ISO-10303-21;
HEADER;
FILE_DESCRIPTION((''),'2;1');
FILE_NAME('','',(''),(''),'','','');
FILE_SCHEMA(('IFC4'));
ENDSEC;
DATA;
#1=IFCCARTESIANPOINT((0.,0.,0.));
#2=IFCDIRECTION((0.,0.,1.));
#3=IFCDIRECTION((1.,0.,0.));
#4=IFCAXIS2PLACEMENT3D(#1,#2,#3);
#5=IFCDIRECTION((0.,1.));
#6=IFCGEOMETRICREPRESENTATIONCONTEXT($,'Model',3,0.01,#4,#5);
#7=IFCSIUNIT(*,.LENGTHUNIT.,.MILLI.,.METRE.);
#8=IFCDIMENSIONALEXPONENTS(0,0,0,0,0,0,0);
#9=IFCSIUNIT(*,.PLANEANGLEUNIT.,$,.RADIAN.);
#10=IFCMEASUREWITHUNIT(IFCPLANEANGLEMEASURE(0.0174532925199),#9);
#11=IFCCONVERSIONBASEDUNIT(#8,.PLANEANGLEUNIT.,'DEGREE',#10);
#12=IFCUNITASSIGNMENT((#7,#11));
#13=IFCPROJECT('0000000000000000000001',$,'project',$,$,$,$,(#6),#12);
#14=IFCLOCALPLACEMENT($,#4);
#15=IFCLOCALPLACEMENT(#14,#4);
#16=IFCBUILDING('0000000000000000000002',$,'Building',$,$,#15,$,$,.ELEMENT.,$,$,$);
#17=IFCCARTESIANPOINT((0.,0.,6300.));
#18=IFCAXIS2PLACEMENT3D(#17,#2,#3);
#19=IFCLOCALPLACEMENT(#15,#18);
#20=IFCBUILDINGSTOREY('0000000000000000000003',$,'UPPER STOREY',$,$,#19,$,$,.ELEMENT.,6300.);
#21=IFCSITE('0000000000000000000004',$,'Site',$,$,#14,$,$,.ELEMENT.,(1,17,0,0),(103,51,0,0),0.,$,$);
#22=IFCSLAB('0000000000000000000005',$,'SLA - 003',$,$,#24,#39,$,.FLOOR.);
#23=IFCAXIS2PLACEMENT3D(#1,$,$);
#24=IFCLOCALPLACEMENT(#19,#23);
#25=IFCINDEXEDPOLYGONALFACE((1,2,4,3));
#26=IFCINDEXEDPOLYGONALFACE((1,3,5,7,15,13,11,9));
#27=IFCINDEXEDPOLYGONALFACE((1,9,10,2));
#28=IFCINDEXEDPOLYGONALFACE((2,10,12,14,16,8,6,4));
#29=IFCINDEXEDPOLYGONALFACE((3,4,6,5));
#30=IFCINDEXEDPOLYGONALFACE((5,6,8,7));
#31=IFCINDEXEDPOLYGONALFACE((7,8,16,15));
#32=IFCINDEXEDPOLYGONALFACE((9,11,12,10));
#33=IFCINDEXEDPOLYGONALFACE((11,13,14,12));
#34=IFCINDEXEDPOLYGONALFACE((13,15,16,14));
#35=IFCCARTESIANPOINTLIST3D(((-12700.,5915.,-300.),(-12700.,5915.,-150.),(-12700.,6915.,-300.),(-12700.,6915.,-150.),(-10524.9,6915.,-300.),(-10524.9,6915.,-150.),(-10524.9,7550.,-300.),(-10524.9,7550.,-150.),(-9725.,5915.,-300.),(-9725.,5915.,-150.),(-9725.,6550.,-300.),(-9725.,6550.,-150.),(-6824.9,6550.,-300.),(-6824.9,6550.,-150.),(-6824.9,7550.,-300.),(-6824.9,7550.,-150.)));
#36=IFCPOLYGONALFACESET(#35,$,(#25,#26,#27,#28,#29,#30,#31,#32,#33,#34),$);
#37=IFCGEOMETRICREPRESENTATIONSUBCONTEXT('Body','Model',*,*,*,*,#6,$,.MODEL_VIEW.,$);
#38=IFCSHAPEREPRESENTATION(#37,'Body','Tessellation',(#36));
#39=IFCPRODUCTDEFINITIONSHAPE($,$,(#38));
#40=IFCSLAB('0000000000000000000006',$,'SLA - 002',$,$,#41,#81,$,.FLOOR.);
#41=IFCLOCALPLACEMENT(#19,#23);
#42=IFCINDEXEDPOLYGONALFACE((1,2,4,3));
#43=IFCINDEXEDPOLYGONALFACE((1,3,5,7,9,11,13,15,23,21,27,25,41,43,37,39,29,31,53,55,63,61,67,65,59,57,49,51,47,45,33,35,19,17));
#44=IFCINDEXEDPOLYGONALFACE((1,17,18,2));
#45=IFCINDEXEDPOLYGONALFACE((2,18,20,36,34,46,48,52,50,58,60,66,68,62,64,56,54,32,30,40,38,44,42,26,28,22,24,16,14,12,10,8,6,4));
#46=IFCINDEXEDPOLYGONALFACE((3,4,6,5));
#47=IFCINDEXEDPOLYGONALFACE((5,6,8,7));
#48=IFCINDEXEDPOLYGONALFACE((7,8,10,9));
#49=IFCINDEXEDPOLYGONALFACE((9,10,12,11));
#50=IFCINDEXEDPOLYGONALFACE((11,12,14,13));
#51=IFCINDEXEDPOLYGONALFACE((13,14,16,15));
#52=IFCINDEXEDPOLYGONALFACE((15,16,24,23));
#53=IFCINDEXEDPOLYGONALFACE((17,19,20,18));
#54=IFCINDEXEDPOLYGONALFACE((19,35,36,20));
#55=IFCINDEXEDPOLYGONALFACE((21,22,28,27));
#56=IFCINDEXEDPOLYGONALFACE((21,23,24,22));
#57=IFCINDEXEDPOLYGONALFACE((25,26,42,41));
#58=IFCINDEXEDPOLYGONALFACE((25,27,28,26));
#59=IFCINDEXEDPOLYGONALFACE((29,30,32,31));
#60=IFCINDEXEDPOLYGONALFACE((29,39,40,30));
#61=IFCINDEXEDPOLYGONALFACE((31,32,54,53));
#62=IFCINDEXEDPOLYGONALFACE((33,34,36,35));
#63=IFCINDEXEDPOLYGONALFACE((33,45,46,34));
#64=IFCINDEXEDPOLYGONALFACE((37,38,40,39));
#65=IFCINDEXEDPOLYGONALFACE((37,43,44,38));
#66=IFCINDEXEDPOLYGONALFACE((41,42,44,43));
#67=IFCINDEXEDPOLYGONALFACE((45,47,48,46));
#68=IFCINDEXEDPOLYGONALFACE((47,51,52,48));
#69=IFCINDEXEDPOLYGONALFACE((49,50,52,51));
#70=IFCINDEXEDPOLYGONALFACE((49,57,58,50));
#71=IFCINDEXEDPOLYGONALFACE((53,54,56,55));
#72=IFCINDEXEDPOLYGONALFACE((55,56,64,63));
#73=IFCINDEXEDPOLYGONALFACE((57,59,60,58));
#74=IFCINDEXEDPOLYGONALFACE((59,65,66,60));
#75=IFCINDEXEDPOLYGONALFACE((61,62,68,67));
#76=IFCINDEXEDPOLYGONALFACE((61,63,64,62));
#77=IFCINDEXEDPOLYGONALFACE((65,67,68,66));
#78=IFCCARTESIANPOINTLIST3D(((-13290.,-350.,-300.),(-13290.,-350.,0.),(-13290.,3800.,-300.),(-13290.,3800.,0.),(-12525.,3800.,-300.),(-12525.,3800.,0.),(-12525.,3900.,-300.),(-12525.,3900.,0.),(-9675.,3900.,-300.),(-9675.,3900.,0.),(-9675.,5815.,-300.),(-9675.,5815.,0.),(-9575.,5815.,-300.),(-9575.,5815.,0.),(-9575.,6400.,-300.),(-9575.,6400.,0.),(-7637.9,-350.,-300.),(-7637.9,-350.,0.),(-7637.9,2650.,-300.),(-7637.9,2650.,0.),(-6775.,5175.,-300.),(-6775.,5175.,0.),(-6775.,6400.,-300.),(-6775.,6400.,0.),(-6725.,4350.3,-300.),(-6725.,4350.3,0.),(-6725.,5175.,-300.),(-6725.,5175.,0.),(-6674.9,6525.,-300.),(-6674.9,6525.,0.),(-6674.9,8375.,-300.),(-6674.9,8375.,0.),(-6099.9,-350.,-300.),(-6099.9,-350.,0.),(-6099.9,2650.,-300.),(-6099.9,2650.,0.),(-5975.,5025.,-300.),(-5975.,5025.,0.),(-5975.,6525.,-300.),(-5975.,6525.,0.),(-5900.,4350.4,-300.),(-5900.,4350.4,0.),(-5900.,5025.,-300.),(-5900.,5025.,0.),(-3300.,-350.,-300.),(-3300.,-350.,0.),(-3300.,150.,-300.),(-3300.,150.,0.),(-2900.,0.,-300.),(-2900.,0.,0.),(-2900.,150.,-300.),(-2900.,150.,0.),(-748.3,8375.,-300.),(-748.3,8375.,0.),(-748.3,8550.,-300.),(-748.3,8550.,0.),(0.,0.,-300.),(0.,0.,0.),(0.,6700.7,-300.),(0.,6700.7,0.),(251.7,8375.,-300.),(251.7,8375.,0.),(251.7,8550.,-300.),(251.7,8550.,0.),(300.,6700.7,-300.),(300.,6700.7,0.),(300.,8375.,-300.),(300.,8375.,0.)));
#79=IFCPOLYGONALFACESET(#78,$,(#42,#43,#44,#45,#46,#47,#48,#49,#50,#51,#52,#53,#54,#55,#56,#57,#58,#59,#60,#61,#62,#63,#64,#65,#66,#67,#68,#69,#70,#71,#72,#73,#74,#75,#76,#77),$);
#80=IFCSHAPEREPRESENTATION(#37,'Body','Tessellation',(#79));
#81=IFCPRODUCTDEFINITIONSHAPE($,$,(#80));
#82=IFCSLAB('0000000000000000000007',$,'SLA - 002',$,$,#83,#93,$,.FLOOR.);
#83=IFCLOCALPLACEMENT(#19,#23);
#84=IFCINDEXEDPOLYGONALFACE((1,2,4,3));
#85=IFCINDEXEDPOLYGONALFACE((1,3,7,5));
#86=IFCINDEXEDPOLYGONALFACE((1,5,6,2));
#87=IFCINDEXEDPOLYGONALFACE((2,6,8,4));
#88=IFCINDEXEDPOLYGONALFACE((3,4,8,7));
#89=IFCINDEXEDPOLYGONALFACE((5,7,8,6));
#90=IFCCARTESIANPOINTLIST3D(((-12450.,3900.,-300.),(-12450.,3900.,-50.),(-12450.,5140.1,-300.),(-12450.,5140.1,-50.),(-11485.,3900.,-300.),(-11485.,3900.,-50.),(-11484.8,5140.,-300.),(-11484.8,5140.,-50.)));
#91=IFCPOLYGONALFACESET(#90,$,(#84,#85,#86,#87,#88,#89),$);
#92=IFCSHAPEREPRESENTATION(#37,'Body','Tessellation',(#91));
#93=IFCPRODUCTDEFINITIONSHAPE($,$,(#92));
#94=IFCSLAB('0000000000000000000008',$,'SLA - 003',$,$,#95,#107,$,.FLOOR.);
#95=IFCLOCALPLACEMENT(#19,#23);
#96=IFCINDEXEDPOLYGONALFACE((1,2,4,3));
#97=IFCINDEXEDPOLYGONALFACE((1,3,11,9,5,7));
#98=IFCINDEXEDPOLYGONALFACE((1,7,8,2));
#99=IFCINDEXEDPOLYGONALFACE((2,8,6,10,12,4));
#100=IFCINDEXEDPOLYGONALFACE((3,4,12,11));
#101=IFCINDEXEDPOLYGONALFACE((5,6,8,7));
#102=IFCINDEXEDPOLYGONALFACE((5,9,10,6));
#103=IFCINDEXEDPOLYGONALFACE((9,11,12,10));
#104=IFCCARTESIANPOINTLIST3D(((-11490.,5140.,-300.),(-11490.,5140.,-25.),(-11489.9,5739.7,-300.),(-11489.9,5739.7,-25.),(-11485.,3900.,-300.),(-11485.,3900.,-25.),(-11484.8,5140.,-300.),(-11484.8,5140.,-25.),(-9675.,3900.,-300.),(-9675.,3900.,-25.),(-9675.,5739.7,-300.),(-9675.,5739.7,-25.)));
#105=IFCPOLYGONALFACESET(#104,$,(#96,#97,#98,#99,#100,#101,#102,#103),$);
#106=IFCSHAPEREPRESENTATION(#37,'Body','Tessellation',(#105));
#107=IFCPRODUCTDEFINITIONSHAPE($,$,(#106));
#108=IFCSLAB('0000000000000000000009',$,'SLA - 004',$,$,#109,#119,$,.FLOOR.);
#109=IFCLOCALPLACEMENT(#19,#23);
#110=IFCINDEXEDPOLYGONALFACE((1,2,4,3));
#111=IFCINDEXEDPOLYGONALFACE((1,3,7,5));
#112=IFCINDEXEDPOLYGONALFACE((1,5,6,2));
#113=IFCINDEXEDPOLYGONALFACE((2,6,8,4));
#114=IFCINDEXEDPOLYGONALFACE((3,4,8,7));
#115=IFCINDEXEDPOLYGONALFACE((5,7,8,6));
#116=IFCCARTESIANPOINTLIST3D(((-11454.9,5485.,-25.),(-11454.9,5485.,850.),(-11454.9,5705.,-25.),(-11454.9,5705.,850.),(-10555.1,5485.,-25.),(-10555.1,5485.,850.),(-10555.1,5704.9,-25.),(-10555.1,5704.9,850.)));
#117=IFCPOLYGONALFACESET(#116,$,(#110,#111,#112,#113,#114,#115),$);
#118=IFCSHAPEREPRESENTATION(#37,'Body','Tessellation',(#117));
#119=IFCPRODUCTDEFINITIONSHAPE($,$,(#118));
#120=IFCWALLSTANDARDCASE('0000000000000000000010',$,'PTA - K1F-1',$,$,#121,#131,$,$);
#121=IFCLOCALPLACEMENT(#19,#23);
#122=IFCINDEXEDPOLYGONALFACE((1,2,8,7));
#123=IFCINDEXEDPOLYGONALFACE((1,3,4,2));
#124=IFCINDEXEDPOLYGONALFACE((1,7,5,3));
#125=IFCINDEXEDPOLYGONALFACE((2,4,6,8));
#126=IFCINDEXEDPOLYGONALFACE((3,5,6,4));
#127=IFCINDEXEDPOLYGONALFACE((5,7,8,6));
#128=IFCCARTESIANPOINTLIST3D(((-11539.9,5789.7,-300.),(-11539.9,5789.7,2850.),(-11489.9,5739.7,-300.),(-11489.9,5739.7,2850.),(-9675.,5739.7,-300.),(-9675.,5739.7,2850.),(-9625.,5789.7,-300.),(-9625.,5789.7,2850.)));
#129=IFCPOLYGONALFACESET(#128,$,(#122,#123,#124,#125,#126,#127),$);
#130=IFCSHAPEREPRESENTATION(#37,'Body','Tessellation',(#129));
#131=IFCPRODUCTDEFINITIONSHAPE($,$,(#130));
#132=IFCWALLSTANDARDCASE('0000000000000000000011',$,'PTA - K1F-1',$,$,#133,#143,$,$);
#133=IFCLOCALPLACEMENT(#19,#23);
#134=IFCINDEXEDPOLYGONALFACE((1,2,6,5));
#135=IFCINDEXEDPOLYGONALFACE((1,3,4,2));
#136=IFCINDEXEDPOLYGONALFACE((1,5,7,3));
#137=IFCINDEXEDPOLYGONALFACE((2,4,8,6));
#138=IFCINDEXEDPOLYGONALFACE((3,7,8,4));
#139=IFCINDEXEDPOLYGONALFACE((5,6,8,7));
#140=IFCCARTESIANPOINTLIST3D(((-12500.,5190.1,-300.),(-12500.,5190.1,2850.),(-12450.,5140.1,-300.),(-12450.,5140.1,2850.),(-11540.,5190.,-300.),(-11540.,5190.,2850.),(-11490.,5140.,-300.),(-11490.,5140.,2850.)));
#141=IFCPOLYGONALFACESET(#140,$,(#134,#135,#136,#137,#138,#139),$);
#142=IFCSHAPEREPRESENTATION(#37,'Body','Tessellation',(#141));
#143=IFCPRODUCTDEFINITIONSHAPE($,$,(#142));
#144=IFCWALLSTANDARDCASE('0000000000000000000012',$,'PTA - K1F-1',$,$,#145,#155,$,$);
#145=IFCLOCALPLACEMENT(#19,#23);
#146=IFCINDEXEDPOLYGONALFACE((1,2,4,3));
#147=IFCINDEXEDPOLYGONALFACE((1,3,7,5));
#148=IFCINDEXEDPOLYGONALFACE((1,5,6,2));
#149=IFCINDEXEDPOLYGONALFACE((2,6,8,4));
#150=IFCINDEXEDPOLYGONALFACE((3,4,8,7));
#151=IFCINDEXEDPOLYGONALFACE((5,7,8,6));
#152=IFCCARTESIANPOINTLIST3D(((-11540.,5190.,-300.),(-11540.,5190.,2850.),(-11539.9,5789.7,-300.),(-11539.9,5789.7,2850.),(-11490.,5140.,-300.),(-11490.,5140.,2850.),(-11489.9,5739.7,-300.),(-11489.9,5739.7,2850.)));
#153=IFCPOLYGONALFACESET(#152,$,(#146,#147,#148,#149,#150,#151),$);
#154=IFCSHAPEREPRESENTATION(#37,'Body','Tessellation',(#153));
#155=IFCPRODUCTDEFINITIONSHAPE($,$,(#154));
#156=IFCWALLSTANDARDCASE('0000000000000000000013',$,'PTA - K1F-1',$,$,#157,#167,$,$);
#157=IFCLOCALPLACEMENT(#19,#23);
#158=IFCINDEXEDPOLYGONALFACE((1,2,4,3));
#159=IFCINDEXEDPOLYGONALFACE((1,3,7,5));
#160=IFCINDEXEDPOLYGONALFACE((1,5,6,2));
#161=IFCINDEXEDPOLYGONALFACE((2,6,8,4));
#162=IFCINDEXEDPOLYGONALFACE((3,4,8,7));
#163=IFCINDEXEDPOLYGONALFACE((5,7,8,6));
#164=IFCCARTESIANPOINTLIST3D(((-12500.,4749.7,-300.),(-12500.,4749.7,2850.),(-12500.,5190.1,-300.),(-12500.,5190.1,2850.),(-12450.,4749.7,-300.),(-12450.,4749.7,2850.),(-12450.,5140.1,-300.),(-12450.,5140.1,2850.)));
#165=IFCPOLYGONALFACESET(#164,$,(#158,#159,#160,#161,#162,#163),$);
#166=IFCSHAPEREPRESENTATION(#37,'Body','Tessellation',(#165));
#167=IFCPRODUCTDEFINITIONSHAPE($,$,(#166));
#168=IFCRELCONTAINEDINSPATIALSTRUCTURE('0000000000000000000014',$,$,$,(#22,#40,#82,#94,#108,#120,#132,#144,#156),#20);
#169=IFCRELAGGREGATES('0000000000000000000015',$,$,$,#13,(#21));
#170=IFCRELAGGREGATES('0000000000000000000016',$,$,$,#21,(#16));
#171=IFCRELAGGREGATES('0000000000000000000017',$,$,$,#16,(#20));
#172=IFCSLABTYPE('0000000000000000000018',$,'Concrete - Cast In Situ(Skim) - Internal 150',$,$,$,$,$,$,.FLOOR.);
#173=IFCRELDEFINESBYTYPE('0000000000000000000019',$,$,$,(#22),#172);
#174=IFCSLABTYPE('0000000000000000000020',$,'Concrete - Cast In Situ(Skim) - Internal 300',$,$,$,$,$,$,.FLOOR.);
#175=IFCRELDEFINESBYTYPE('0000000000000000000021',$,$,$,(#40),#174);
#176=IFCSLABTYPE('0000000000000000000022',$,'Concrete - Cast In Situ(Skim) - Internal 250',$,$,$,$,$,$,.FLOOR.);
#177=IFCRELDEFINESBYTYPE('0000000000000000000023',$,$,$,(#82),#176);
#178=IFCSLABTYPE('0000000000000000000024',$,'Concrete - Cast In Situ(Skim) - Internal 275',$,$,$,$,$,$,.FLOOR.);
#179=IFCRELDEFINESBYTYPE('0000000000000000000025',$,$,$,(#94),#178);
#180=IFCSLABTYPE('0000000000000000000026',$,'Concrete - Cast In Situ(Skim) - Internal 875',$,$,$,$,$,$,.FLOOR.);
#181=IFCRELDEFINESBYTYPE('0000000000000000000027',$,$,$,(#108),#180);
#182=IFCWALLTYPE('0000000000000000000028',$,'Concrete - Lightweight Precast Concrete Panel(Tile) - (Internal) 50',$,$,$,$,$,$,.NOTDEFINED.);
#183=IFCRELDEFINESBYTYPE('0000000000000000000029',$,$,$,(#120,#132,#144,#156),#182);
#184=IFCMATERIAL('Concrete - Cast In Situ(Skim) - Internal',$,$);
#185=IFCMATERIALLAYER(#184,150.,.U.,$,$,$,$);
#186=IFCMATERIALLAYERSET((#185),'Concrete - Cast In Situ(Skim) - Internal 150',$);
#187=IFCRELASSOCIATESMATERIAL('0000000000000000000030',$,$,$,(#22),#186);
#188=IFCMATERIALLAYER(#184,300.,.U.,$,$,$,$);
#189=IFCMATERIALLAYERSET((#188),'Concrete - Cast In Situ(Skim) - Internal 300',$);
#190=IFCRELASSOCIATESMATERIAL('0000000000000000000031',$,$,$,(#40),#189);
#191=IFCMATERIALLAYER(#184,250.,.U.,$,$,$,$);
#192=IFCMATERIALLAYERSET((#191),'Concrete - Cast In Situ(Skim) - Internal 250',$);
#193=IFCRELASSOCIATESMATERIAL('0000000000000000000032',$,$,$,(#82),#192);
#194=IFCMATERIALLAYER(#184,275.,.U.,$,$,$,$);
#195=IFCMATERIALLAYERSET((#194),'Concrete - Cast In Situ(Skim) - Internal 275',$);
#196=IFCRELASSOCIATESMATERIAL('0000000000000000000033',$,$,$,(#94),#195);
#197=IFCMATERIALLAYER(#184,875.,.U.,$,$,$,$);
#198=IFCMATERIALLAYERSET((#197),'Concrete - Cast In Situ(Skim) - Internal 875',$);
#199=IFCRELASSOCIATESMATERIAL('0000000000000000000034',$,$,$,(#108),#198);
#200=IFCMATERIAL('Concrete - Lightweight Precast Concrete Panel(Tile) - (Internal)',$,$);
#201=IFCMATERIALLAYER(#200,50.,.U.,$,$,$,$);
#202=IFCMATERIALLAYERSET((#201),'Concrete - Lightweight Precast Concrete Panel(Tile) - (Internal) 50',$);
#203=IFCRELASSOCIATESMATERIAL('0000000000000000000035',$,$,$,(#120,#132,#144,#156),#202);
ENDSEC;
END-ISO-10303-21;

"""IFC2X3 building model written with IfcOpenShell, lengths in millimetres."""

from ifc_helpers import new_model, entity, si_unit, converted_unit, direction, frame, origin_with_axes, place, context, subcontext, project, spatial, polyline, outline, extrude, material, layer, layer_set, layer_usage, type_object, element, save


model = new_model("IFC2X3")

# Units and contexts
model_context = context("Model", 3, precision=0.01, world=origin_with_axes(), true_north=direction((0.0, 1.0)))
body_context = subcontext(model_context, "Body", "Model", "MODEL_VIEW")
ifc_project = project(units=[si_unit("LENGTHUNIT", "METRE", prefix="MILLI"), converted_unit("PLANEANGLEUNIT", "DEGREE", entity("IfcPlaneAngleMeasure", 0.0174532925199), si_unit("PLANEANGLEUNIT", "RADIAN"), dimensions=[0, 0, 0, 0, 0, 0, 0])], contexts=[model_context])

# Site, building, storey
site_placement = place(None, origin_with_axes())
site = spatial("IfcSite", under=ifc_project, at=site_placement, Name="Site", CompositionType="ELEMENT", RefLatitude=(1, 17, 0, 0), RefLongitude=(103, 51, 0, 0), RefElevation=0.0)
building_placement = place(site_placement, origin_with_axes())
building = spatial("IfcBuilding", under=site, at=building_placement, Name="Building", CompositionType="ELEMENT")
storey_placement = place(building_placement, frame((0.0, 0.0, 6300.0), z_axis=(0.0, 0.0, 1.0), x_axis=(1.0, 0.0, 0.0)))
storey = spatial("IfcBuildingStorey", under=building, at=storey_placement, Name="UPPER STOREY", CompositionType="ELEMENT", Elevation=6300.0)

# Slabs
ifc_material_1 = material(Name="Concrete - Cast In Situ(Skim) - Internal")
ifc_layer_1 = layer(ifc_material_1, 150.0, ventilated="UNKNOWN")
ifc_layer_set_1 = layer_set([ifc_layer_1], Name="Concrete - Cast In Situ(Skim) - Internal 150")
ifc_layer_usage_1 = layer_usage(ifc_layer_set_1, "AXIS3", "NEGATIVE", 150.0)
slab_type_1 = type_object("IfcSlabType", Name="Concrete - Cast In Situ(Skim) - Internal 150", PredefinedType="FLOOR")
slab_1_placement = place(storey_placement, frame((-12700.0, 5915.0, -150.0), z_axis=(0.0, 0.0, 1.0), x_axis=(1.0, 0.0, 0.0)))
element("IfcSlab", 1, at=slab_1_placement, inside=storey, type_object=slab_type_1, material=ifc_layer_usage_1, Name="SLA - 003", PredefinedType="FLOOR", context=body_context, shape_type="SweptSolid", body=[
    extrude(outline(polyline([(0.0, 0.0), (2975.0, 0.0), (2975.0, 635.0), (5875.0, 635.0), (5875.0, 1635.0), (2175.1, 1635.0), (2175.1, 1000.0), (0.0, 1000.0), (0.0, 0.0)])), frame((0.0, 0.0, -150.0), z_axis=(0.0, 0.0, 1.0), x_axis=(1.0, 0.0, 0.0)), (0.0, 0.0, 1.0), 150.0),
])
ifc_layer_2 = layer(ifc_material_1, 300.0, ventilated="UNKNOWN")
ifc_layer_set_2 = layer_set([ifc_layer_2], Name="Concrete - Cast In Situ(Skim) - Internal 300")
ifc_layer_usage_2 = layer_usage(ifc_layer_set_2, "AXIS3", "NEGATIVE", 300.0)
slab_type_2 = type_object("IfcSlabType", Name="Concrete - Cast In Situ(Skim) - Internal 300", PredefinedType="FLOOR")
slab_2_placement = place(storey_placement, frame((-13290.0, 3800.0, 0.0), z_axis=(0.0, 0.0, 1.0), x_axis=(1.0, 0.0, 0.0)))
element("IfcSlab", 2, at=slab_2_placement, inside=storey, type_object=slab_type_2, material=ifc_layer_usage_2, Name="SLA - 002", PredefinedType="FLOOR", context=body_context, shape_type="SweptSolid", body=[
    extrude(outline(polyline([(0.0, 0.0), (0.0, -4150.0), (5652.1, -4150.0), (5652.1, -1150.0), (7190.1, -1150.0), (7190.1, -4150.0), (9990.0, -4150.0), (9990.0, -3650.0), (10390.0, -3650.0), (10390.0, -3800.0), (13290.0, -3800.0), (13290.0, 2900.7), (13590.0, 2900.7), (13590.0, 4575.0), (13541.7, 4575.0), (13541.7, 4750.0), (12541.7, 4750.0), (12541.7, 4575.0), (6615.1, 4575.0), (6615.1, 2725.0), (7315.0, 2725.0), (7315.0, 1225.0), (7390.0, 1225.0), (7390.0, 550.4), (6565.0, 550.3), (6565.0, 1375.0), (6515.0, 1375.0), (6515.0, 2600.0), (3715.0, 2600.0), (3715.0, 2015.0), (3615.0, 2015.0), (3615.0, 100.0), (765.0, 100.0), (765.0, 0.0), (0.0, 0.0)])), frame((0.0, 0.0, -300.0), z_axis=(0.0, 0.0, 1.0), x_axis=(1.0, 0.0, 0.0)), (0.0, 0.0, 1.0), 300.0),
])
ifc_layer_3 = layer(ifc_material_1, 250.0, ventilated="UNKNOWN")
ifc_layer_set_3 = layer_set([ifc_layer_3], Name="Concrete - Cast In Situ(Skim) - Internal 250")
ifc_layer_usage_3 = layer_usage(ifc_layer_set_3, "AXIS3", "NEGATIVE", 250.0)
slab_type_3 = type_object("IfcSlabType", Name="Concrete - Cast In Situ(Skim) - Internal 250", PredefinedType="FLOOR")
slab_3_placement = place(storey_placement, frame((-12450.0, 5140.1, -50.0), z_axis=(0.0, 0.0, 1.0), x_axis=(1.0, 0.0, 0.0)))
element("IfcSlab", 3, at=slab_3_placement, inside=storey, type_object=slab_type_3, material=ifc_layer_usage_3, Name="SLA - 002", PredefinedType="FLOOR", context=body_context, shape_type="SweptSolid", body=[
    extrude(outline(polyline([(0.0, 0.0), (0.0, -1240.1), (965.0, -1240.1), (965.1, -0.1), (0.0, 0.0)])), frame((0.0, 0.0, -250.0), z_axis=(0.0, 0.0, 1.0), x_axis=(1.0, 0.0, 0.0)), (0.0, 0.0, 1.0), 250.0),
])
ifc_layer_4 = layer(ifc_material_1, 275.0, ventilated="UNKNOWN")
ifc_layer_set_4 = layer_set([ifc_layer_4], Name="Concrete - Cast In Situ(Skim) - Internal 275")
ifc_layer_usage_4 = layer_usage(ifc_layer_set_4, "AXIS3", "NEGATIVE", 275.0)
slab_type_4 = type_object("IfcSlabType", Name="Concrete - Cast In Situ(Skim) - Internal 275", PredefinedType="FLOOR")
slab_4_placement = place(storey_placement, frame((-11485.0, 3900.0, -25.0), z_axis=(0.0, 0.0, 1.0), x_axis=(1.0, 0.0, 0.0)))
element("IfcSlab", 4, at=slab_4_placement, inside=storey, type_object=slab_type_4, material=ifc_layer_usage_4, Name="SLA - 003", PredefinedType="FLOOR", context=body_context, shape_type="SweptSolid", body=[
    extrude(outline(polyline([(0.0, 0.0), (1810.0, 0.0), (1810.0, 1839.7), (-5.0, 1839.7), (-5.0, 1240.0), (0.1, 1240.0), (0.0, 0.0)])), frame((0.0, 0.0, -275.0), z_axis=(0.0, 0.0, 1.0), x_axis=(1.0, 0.0, 0.0)), (0.0, 0.0, 1.0), 275.0),
])
ifc_layer_5 = layer(ifc_material_1, 875.0, ventilated="UNKNOWN")
ifc_layer_set_5 = layer_set([ifc_layer_5], Name="Concrete - Cast In Situ(Skim) - Internal 875")
ifc_layer_usage_5 = layer_usage(ifc_layer_set_5, "AXIS3", "NEGATIVE", 875.0)
slab_type_5 = type_object("IfcSlabType", Name="Concrete - Cast In Situ(Skim) - Internal 875", PredefinedType="FLOOR")
slab_5_placement = place(storey_placement, frame((-11454.9, 5705.0, 850.0), z_axis=(0.0, 0.0, 1.0), x_axis=(1.0, 0.0, 0.0)))
element("IfcSlab", 5, at=slab_5_placement, inside=storey, type_object=slab_type_5, material=ifc_layer_usage_5, Name="SLA - 004", PredefinedType="FLOOR", context=body_context, shape_type="SweptSolid", body=[
    extrude(outline(polyline([(0.0, 0.0), (0.0, -219.9), (899.7, -220.0), (899.7, 0.0), (0.0, 0.0)])), frame((0.0, 0.0, -875.0), z_axis=(0.0, 0.0, 1.0), x_axis=(1.0, 0.0, 0.0)), (0.0, 0.0, 1.0), 875.0),
])

# Walls
ifc_material_2 = material(Name="Concrete - Lightweight Precast Concrete Panel(Tile) - (Internal)")
ifc_layer_6 = layer(ifc_material_2, 50.0, ventilated="UNKNOWN")
ifc_layer_set_6 = layer_set([ifc_layer_6], Name="Concrete - Lightweight Precast Concrete Panel(Tile) - (Internal) 50")
ifc_layer_usage_6 = layer_usage(ifc_layer_set_6, "AXIS2", "NEGATIVE", 0.0)
wall_type_1 = type_object("IfcWallType", Name="Concrete - Lightweight Precast Concrete Panel(Tile) - (Internal) 50", PredefinedType="NOTDEFINED")
wall_1_placement = place(storey_placement, frame((-11489.9, 5789.7, -300.0), z_axis=(0.0, 0.0, 1.0), x_axis=(1.0, 0.000001, 0.0)))
element("IfcWallStandardCase", 6, at=wall_1_placement, inside=storey, type_object=wall_type_1, material=ifc_layer_usage_6, Name="PTA - K1F-1", context=body_context, shape_type="SweptSolid", body=[
    extrude(outline(polyline([(0.0, -50.0), (1815.0, -50.0), (1865.0, 0.0), (-50.0, 0.0), (0.0, -50.0)])), origin_with_axes(), (0.0, 0.0, 1.0), 3150.0),
])
ifc_layer_usage_7 = layer_usage(ifc_layer_set_6, "AXIS2", "NEGATIVE", 0.0)
wall_2_placement = place(storey_placement, frame((-11490.0, 5140.0, -300.0), z_axis=(0.0, 0.0, 1.0), x_axis=(-1.0, 0.00009, 0.0)))
element("IfcWallStandardCase", 7, at=wall_2_placement, inside=storey, type_object=wall_type_1, material=ifc_layer_usage_7, Name="PTA - K1F-1", context=body_context, shape_type="SweptSolid", body=[
    extrude(outline(polyline([(50.0, -50.0), (1010.0, -50.0), (960.0, 0.0), (0.0, 0.0), (50.0, -50.0)])), origin_with_axes(), (0.0, 0.0, 1.0), 3150.0),
])
ifc_layer_usage_8 = layer_usage(ifc_layer_set_6, "AXIS2", "NEGATIVE", 0.0)
wall_3_placement = place(storey_placement, frame((-11489.9, 5789.7, -300.0), z_axis=(0.0, 0.0, 1.0), x_axis=(-0.00009, -1.0, 0.0)))
element("IfcWallStandardCase", 8, at=wall_3_placement, inside=storey, type_object=wall_type_1, material=ifc_layer_usage_8, Name="PTA - K1F-1", context=body_context, shape_type="SweptSolid", body=[
    extrude(outline(polyline([(0.0, -50.0), (599.7, -50.0), (649.7, 0.0), (50.0, 0.0), (0.0, -50.0)])), origin_with_axes(), (0.0, 0.0, 1.0), 3150.0),
])
ifc_layer_usage_9 = layer_usage(ifc_layer_set_6, "AXIS2", "NEGATIVE", 0.0)
wall_4_placement = place(storey_placement, frame((-12500.0, 4749.7, -300.0), z_axis=(0.0, 0.0, 1.0), x_axis=(0.0, 1.0, 0.0)))
element("IfcWallStandardCase", 9, at=wall_4_placement, inside=storey, type_object=wall_type_1, material=ifc_layer_usage_9, Name="PTA - K1F-1", context=body_context, shape_type="SweptSolid", body=[
    extrude(outline(polyline([(0.0, -50.0), (390.4, -50.0), (440.4, 0.0), (0.0, 0.0), (0.0, -50.0)])), origin_with_axes(), (0.0, 0.0, 1.0), 3150.0),
])

save(model, "model.ifc")
